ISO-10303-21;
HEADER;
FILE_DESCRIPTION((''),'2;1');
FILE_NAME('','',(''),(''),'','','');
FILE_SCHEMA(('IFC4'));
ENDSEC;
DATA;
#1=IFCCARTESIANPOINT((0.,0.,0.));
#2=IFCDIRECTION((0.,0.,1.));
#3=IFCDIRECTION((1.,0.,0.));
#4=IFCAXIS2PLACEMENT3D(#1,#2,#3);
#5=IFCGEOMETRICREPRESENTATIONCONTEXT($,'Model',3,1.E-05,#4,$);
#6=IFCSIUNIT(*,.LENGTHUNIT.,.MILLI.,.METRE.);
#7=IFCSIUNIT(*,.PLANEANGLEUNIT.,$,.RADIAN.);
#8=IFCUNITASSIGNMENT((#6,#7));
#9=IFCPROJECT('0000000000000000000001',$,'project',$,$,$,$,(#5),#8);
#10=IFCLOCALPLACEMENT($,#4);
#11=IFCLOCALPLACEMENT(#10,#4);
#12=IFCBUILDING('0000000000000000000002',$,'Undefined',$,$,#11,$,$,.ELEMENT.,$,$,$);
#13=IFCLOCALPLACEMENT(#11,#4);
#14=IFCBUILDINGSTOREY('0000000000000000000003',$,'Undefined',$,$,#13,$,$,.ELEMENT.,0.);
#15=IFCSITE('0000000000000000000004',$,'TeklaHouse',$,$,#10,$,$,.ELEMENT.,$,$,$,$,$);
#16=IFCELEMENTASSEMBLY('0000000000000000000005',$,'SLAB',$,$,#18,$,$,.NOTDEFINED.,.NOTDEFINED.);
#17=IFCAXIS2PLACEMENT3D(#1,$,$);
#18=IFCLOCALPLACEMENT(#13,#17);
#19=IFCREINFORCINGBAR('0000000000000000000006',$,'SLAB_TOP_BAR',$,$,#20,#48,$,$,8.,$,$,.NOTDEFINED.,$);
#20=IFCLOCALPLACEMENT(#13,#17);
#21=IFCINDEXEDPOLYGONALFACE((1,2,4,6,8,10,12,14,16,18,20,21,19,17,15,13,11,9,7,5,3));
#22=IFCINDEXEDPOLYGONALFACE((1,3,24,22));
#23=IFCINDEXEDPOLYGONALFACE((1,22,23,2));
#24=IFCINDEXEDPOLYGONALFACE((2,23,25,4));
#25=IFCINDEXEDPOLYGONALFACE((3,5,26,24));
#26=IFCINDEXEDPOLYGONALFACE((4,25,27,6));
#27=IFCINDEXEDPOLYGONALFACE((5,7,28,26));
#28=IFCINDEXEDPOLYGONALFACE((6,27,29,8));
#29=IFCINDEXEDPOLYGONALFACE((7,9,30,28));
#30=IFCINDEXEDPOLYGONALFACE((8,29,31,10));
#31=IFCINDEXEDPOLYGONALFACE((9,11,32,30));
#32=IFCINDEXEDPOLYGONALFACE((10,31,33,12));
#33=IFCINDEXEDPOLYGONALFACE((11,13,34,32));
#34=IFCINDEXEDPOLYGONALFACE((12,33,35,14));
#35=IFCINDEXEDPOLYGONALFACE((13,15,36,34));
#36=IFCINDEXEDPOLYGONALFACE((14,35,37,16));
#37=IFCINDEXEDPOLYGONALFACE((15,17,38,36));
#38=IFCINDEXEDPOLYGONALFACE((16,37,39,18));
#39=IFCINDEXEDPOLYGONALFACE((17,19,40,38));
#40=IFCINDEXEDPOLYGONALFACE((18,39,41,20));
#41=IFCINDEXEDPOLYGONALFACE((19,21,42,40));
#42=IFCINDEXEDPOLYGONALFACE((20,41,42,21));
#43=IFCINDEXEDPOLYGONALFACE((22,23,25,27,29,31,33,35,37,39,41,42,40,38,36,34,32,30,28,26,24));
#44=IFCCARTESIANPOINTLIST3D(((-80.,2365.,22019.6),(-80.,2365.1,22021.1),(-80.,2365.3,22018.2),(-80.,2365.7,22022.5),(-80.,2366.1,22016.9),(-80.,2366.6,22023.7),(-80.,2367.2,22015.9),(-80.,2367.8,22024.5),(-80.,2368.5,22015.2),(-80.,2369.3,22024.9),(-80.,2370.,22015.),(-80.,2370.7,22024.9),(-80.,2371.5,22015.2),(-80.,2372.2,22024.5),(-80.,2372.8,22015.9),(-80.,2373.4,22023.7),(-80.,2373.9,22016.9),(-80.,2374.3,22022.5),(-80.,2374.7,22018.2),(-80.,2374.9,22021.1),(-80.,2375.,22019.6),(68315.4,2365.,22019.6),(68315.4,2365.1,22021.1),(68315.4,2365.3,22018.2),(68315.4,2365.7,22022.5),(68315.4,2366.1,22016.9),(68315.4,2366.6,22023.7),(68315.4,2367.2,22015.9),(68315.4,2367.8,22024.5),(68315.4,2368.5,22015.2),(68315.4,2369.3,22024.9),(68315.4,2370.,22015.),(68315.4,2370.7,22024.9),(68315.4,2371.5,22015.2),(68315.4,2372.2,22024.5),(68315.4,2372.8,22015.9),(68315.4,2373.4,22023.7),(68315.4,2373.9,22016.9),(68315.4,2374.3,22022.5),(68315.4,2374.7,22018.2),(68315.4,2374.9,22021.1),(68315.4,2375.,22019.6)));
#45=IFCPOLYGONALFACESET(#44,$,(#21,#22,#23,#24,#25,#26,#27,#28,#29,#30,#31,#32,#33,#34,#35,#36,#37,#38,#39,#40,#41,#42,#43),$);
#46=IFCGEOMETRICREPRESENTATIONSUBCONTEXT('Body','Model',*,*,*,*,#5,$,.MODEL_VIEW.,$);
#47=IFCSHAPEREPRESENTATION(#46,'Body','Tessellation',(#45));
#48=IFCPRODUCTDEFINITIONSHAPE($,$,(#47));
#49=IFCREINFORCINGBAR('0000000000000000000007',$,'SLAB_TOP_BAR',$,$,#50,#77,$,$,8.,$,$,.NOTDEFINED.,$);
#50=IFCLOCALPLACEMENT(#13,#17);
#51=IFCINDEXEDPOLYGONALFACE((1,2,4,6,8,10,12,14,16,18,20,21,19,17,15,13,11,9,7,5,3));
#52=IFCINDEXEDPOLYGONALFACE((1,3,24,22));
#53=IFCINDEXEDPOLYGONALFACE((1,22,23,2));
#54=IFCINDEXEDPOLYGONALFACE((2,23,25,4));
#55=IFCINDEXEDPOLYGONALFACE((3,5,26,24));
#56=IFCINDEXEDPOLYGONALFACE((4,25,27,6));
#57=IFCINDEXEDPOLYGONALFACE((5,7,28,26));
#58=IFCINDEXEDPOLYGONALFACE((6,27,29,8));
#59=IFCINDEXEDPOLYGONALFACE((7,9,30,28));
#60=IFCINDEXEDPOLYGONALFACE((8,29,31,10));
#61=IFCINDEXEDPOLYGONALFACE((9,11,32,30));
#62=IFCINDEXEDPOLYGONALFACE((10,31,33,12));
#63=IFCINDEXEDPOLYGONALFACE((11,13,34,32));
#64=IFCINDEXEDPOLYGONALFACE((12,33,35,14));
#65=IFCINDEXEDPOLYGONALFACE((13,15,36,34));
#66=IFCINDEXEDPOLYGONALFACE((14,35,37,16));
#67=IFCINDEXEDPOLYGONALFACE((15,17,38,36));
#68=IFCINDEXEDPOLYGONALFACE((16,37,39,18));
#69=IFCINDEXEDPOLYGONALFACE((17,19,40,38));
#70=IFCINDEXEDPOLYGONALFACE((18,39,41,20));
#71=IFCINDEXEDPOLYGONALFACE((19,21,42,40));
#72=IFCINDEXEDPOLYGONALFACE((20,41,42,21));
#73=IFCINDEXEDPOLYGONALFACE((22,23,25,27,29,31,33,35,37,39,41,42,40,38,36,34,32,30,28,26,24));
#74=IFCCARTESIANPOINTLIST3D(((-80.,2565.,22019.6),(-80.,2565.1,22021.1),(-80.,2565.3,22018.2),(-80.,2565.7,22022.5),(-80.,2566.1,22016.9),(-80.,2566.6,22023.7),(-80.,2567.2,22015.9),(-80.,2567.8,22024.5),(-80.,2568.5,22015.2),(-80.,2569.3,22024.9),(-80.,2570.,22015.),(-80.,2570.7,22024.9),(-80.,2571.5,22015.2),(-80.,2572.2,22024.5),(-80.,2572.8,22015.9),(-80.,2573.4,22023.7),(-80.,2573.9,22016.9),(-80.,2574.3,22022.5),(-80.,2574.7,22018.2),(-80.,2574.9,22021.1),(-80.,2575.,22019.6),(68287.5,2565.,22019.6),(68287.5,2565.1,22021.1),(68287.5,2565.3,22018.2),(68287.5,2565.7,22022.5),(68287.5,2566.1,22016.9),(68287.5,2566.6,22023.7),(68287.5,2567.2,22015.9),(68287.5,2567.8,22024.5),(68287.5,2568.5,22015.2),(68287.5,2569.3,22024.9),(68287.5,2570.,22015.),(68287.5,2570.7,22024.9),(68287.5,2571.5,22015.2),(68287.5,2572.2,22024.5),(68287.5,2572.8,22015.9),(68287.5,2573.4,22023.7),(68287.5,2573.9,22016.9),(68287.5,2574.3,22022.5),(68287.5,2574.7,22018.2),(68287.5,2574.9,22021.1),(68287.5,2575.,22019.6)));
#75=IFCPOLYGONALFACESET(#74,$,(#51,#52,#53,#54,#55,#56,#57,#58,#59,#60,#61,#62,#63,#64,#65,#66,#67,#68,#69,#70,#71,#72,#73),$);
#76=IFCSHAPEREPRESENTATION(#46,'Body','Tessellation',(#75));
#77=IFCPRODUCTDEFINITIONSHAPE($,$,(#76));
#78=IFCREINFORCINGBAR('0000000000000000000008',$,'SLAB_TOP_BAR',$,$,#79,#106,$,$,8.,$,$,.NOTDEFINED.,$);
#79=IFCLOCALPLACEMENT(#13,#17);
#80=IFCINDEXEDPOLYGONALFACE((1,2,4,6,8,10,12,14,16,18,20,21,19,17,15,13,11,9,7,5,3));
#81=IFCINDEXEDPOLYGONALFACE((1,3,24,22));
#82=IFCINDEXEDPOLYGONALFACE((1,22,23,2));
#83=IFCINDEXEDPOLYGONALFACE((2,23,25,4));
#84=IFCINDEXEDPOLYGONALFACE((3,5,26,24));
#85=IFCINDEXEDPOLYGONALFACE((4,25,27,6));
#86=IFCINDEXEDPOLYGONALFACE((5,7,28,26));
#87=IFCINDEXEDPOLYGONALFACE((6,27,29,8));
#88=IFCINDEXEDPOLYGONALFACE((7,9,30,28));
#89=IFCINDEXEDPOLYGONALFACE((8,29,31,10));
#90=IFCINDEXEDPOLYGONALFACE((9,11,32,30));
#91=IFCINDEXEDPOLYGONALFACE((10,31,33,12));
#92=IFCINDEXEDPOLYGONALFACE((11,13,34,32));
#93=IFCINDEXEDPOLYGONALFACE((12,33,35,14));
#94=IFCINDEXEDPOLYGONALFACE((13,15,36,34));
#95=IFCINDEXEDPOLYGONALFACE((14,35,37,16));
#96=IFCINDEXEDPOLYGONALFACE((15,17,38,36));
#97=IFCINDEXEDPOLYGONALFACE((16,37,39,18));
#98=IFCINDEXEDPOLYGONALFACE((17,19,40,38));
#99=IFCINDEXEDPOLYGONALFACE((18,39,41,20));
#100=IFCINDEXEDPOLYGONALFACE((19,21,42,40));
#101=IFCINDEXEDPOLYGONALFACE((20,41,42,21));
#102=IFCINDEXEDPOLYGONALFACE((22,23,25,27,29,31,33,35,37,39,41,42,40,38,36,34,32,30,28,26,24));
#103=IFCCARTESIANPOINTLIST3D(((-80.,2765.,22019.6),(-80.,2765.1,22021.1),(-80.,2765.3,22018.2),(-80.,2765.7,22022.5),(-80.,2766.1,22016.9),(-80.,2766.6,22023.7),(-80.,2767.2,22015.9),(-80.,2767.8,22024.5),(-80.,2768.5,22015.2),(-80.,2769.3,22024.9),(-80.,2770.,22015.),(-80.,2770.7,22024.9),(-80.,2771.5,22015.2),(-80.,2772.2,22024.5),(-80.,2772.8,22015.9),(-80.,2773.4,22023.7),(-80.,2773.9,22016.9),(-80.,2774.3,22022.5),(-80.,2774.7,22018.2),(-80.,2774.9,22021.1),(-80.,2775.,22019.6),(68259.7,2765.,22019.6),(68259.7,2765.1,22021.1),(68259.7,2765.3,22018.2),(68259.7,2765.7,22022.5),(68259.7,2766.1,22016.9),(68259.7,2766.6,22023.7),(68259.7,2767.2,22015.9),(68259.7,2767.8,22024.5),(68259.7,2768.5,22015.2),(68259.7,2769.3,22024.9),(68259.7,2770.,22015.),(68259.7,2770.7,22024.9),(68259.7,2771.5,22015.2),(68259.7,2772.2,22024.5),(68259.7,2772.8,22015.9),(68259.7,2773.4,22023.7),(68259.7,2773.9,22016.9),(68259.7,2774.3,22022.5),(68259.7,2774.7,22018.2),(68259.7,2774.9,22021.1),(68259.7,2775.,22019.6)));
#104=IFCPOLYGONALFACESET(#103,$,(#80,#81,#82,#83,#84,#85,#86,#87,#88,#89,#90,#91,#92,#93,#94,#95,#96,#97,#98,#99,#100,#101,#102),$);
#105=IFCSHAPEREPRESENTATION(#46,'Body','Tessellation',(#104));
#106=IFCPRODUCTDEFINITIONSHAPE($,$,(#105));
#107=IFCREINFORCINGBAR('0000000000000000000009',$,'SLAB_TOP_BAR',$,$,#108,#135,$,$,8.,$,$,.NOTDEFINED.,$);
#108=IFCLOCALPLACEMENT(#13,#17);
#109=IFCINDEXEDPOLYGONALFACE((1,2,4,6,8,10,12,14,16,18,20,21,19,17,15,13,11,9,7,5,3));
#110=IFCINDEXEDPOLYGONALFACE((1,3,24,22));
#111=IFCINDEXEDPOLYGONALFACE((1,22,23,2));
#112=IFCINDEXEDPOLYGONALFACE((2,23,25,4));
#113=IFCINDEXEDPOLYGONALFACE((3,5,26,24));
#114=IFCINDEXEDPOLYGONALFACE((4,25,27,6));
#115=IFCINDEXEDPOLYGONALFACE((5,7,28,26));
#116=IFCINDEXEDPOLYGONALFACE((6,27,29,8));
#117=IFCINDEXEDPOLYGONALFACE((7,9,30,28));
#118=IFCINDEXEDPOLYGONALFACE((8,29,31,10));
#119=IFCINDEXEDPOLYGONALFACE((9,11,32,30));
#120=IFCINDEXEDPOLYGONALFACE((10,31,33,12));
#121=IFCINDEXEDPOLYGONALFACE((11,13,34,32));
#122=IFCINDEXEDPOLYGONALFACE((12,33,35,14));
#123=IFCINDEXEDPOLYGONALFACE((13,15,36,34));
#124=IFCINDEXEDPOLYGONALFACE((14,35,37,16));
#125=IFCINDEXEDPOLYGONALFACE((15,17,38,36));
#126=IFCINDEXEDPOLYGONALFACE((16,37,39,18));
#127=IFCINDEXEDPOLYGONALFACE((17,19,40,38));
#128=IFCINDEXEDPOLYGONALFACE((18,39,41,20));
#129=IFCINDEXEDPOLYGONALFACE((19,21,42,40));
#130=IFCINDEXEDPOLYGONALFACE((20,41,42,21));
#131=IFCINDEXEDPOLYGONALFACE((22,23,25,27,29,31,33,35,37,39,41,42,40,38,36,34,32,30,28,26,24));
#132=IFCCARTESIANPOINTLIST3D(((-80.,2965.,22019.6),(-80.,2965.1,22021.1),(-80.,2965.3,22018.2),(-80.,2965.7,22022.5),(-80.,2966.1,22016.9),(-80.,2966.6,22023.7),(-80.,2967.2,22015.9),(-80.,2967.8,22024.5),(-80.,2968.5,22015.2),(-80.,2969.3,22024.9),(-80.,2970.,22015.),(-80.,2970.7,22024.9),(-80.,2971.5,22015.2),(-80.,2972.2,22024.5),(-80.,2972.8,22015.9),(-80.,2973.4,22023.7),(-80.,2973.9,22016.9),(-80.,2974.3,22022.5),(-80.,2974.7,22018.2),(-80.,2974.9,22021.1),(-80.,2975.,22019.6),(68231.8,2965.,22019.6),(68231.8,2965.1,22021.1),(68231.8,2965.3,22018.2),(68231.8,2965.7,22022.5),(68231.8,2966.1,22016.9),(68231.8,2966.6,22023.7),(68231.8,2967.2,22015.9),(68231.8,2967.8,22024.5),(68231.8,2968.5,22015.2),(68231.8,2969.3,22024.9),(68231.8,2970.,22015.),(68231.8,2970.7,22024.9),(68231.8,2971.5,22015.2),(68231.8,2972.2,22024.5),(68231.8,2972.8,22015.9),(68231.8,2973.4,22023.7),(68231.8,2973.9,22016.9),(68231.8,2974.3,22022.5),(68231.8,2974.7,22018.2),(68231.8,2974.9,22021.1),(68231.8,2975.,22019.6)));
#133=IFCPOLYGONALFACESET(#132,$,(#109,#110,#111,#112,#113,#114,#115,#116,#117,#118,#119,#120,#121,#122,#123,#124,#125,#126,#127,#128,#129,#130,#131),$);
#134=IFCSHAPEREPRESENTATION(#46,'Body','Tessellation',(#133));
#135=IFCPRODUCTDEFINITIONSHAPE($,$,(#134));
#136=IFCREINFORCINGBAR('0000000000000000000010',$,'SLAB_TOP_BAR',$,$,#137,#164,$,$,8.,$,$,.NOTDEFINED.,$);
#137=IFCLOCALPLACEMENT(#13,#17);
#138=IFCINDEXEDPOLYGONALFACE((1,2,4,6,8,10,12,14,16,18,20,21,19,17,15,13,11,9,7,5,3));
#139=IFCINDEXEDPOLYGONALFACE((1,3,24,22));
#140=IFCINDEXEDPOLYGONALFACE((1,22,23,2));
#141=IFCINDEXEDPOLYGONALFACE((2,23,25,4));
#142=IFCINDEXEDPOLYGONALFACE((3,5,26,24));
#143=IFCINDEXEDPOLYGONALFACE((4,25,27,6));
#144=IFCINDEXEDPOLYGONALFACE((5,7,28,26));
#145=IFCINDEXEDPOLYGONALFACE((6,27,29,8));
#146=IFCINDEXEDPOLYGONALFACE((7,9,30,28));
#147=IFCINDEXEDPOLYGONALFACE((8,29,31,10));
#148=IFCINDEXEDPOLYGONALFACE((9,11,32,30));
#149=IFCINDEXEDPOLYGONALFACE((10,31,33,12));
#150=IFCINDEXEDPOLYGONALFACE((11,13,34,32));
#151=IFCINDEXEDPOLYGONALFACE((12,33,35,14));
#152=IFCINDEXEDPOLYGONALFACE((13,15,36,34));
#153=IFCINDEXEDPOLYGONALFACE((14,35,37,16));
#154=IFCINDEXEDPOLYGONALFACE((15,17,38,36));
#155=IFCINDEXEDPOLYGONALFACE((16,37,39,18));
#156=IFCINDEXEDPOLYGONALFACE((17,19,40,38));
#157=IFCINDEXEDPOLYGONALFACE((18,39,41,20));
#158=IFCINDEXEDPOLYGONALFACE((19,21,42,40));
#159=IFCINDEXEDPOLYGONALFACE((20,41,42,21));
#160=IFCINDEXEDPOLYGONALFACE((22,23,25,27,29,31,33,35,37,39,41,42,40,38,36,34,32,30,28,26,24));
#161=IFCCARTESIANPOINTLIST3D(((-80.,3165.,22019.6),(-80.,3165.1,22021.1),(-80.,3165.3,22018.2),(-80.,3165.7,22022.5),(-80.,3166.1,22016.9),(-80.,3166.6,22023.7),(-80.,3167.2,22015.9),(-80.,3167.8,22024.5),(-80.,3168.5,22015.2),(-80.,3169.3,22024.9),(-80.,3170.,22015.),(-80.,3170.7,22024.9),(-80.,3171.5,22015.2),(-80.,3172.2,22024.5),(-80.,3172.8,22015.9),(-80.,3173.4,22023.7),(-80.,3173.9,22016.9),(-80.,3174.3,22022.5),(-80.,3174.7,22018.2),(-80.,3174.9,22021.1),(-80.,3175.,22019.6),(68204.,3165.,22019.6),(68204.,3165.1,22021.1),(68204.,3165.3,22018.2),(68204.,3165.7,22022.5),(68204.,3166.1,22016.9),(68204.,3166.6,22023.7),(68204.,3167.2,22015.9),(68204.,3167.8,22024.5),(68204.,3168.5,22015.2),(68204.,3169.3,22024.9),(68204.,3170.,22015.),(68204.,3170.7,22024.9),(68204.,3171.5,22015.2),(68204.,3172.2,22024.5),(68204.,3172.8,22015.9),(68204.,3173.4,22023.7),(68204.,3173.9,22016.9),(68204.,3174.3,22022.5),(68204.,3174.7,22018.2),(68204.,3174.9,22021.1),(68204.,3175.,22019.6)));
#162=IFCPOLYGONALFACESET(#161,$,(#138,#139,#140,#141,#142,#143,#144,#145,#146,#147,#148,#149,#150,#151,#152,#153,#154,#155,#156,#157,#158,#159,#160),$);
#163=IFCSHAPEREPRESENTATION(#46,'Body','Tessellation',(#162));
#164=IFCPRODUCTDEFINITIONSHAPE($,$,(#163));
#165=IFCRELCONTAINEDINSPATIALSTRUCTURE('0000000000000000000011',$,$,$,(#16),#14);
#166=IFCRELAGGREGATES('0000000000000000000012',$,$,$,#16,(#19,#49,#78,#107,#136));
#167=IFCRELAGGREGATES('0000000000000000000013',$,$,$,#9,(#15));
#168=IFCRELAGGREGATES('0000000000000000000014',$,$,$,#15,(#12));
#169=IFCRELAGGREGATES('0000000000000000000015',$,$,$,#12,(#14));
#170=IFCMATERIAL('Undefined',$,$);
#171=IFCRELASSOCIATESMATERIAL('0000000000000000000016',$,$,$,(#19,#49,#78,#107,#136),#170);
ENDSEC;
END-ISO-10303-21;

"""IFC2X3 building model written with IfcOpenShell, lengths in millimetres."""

from ifc_helpers import new_model, entity, si_unit, frame, origin_with_axes, place, context, subcontext, project, spatial, source, transform, mapped, material, element, aggregate, save


model = new_model("IFC2X3")

# Units and contexts
model_context = context("Model", 3, precision=1e-05, world=origin_with_axes())
body_context = subcontext(model_context, "Body", "Model", "MODEL_VIEW")
ifc_project = project(units=[si_unit("LENGTHUNIT", "METRE", prefix="MILLI"), si_unit("PLANEANGLEUNIT", "RADIAN")], contexts=[model_context])

# Site, building, storey
site_placement = place(None, origin_with_axes())
site = spatial("IfcSite", under=ifc_project, at=site_placement, Name="TeklaHouse", CompositionType="ELEMENT")
building_placement = place(site_placement, origin_with_axes())
building = spatial("IfcBuilding", under=site, at=building_placement, Name="Undefined", CompositionType="ELEMENT")
storey_placement = place(building_placement, origin_with_axes())
storey = spatial("IfcBuildingStorey", under=building, at=storey_placement, Name="Undefined", CompositionType="ELEMENT", Elevation=0.0)

# Shared definitions
ifc_material_1 = material(Name="Undefined")

# Element assembly, reinforcing bars
assembly_1_placement = place(storey_placement, origin_with_axes())
assembly_1 = element("IfcElementAssembly", 1, at=assembly_1_placement, inside=storey, Name="SLAB", AssemblyPlace="NOTDEFINED", PredefinedType="NOTDEFINED")
shared_shape_1 = source(origin_with_axes(), body_context, "Body", "AdvancedSweptSolid", [
    entity("IfcSweptDiskSolid", entity("IfcTrimmedCurve", entity("IfcLine", entity("IfcCartesianPoint", [0.0, 0.0, 0.0]), entity("IfcVector", entity("IfcDirection", [1.0, 0.0, 0.0]), 1.0)), [entity("IfcParameterValue", 0.0)], [entity("IfcParameterValue", 68395.355223)], True, "PARAMETER"), 5.0, None, 0.0, 68395.4),
])
reinforcing_bar_1_placement = place(assembly_1_placement, frame((68315.4, 2370.0, 22020.0), z_axis=(0.0, 0.0, -1.0), x_axis=(-1.0, 0.0, 0.0)))
reinforcing_bar_1 = element("IfcReinforcingBar", 2, at=reinforcing_bar_1_placement, material=ifc_material_1, Name="SLAB_TOP_BAR", BarRole="NOTDEFINED", NominalDiameter=8.0, context=body_context, shape_type="MappedRepresentation", body=[
    mapped(shared_shape_1, transform((0.0, 0.0, 0.0))),
])
shared_shape_2 = source(origin_with_axes(), body_context, "Body", "AdvancedSweptSolid", [
    entity("IfcSweptDiskSolid", entity("IfcTrimmedCurve", entity("IfcLine", entity("IfcCartesianPoint", [0.0, 0.0, 0.0]), entity("IfcVector", entity("IfcDirection", [1.0, 0.0, 0.0]), 1.0)), [entity("IfcParameterValue", 0.0)], [entity("IfcParameterValue", 68367.508766)], True, "PARAMETER"), 5.0, None, 0.0, 68367.5),
])
reinforcing_bar_2_placement = place(assembly_1_placement, frame((68287.5, 2570.0, 22020.0), z_axis=(0.0, 0.0, -1.0), x_axis=(-1.0, 0.0, 0.0)))
reinforcing_bar_2 = element("IfcReinforcingBar", 3, at=reinforcing_bar_2_placement, material=ifc_material_1, Name="SLAB_TOP_BAR", BarRole="NOTDEFINED", NominalDiameter=8.0, context=body_context, shape_type="MappedRepresentation", body=[
    mapped(shared_shape_2, transform((0.0, 0.0, 0.0))),
])
shared_shape_3 = source(origin_with_axes(), body_context, "Body", "AdvancedSweptSolid", [
    entity("IfcSweptDiskSolid", entity("IfcTrimmedCurve", entity("IfcLine", entity("IfcCartesianPoint", [0.0, 0.0, 0.0]), entity("IfcVector", entity("IfcDirection", [1.0, 0.0, 0.0]), 1.0)), [entity("IfcParameterValue", 0.0)], [entity("IfcParameterValue", 68339.662309)], True, "PARAMETER"), 5.0, None, 0.0, 68339.7),
])
reinforcing_bar_3_placement = place(assembly_1_placement, frame((68259.7, 2770.0, 22020.0), z_axis=(0.0, 0.0, -1.0), x_axis=(-1.0, 0.0, 0.0)))
reinforcing_bar_3 = element("IfcReinforcingBar", 4, at=reinforcing_bar_3_placement, material=ifc_material_1, Name="SLAB_TOP_BAR", BarRole="NOTDEFINED", NominalDiameter=8.0, context=body_context, shape_type="MappedRepresentation", body=[
    mapped(shared_shape_3, transform((0.0, 0.0, 0.0))),
])
shared_shape_4 = source(origin_with_axes(), body_context, "Body", "AdvancedSweptSolid", [
    entity("IfcSweptDiskSolid", entity("IfcTrimmedCurve", entity("IfcLine", entity("IfcCartesianPoint", [0.0, 0.0, 0.0]), entity("IfcVector", entity("IfcDirection", [1.0, 0.0, 0.0]), 1.0)), [entity("IfcParameterValue", 0.0)], [entity("IfcParameterValue", 68311.815852)], True, "PARAMETER"), 5.0, None, 0.0, 68311.8),
])
reinforcing_bar_4_placement = place(assembly_1_placement, frame((68231.8, 2970.0, 22020.0), z_axis=(0.0, 0.0, -1.0), x_axis=(-1.0, 0.0, 0.0)))
reinforcing_bar_4 = element("IfcReinforcingBar", 5, at=reinforcing_bar_4_placement, material=ifc_material_1, Name="SLAB_TOP_BAR", BarRole="NOTDEFINED", NominalDiameter=8.0, context=body_context, shape_type="MappedRepresentation", body=[
    mapped(shared_shape_4, transform((0.0, 0.0, 0.0))),
])
shared_shape_5 = source(origin_with_axes(), body_context, "Body", "AdvancedSweptSolid", [
    entity("IfcSweptDiskSolid", entity("IfcTrimmedCurve", entity("IfcLine", entity("IfcCartesianPoint", [0.0, 0.0, 0.0]), entity("IfcVector", entity("IfcDirection", [1.0, 0.0, 0.0]), 1.0)), [entity("IfcParameterValue", 0.0)], [entity("IfcParameterValue", 68283.969395)], True, "PARAMETER"), 5.0, None, 0.0, 68284.0),
])
reinforcing_bar_5_placement = place(assembly_1_placement, frame((68204.0, 3170.0, 22020.0), z_axis=(0.0, 0.0, -1.0), x_axis=(-1.0, 0.0, 0.0)))
reinforcing_bar_5 = element("IfcReinforcingBar", 6, at=reinforcing_bar_5_placement, material=ifc_material_1, Name="SLAB_TOP_BAR", BarRole="NOTDEFINED", NominalDiameter=8.0, context=body_context, shape_type="MappedRepresentation", body=[
    mapped(shared_shape_5, transform((0.0, 0.0, 0.0))),
])
aggregate(assembly_1, [reinforcing_bar_1, reinforcing_bar_2, reinforcing_bar_3, reinforcing_bar_4, reinforcing_bar_5])

save(model, "model.ifc")
